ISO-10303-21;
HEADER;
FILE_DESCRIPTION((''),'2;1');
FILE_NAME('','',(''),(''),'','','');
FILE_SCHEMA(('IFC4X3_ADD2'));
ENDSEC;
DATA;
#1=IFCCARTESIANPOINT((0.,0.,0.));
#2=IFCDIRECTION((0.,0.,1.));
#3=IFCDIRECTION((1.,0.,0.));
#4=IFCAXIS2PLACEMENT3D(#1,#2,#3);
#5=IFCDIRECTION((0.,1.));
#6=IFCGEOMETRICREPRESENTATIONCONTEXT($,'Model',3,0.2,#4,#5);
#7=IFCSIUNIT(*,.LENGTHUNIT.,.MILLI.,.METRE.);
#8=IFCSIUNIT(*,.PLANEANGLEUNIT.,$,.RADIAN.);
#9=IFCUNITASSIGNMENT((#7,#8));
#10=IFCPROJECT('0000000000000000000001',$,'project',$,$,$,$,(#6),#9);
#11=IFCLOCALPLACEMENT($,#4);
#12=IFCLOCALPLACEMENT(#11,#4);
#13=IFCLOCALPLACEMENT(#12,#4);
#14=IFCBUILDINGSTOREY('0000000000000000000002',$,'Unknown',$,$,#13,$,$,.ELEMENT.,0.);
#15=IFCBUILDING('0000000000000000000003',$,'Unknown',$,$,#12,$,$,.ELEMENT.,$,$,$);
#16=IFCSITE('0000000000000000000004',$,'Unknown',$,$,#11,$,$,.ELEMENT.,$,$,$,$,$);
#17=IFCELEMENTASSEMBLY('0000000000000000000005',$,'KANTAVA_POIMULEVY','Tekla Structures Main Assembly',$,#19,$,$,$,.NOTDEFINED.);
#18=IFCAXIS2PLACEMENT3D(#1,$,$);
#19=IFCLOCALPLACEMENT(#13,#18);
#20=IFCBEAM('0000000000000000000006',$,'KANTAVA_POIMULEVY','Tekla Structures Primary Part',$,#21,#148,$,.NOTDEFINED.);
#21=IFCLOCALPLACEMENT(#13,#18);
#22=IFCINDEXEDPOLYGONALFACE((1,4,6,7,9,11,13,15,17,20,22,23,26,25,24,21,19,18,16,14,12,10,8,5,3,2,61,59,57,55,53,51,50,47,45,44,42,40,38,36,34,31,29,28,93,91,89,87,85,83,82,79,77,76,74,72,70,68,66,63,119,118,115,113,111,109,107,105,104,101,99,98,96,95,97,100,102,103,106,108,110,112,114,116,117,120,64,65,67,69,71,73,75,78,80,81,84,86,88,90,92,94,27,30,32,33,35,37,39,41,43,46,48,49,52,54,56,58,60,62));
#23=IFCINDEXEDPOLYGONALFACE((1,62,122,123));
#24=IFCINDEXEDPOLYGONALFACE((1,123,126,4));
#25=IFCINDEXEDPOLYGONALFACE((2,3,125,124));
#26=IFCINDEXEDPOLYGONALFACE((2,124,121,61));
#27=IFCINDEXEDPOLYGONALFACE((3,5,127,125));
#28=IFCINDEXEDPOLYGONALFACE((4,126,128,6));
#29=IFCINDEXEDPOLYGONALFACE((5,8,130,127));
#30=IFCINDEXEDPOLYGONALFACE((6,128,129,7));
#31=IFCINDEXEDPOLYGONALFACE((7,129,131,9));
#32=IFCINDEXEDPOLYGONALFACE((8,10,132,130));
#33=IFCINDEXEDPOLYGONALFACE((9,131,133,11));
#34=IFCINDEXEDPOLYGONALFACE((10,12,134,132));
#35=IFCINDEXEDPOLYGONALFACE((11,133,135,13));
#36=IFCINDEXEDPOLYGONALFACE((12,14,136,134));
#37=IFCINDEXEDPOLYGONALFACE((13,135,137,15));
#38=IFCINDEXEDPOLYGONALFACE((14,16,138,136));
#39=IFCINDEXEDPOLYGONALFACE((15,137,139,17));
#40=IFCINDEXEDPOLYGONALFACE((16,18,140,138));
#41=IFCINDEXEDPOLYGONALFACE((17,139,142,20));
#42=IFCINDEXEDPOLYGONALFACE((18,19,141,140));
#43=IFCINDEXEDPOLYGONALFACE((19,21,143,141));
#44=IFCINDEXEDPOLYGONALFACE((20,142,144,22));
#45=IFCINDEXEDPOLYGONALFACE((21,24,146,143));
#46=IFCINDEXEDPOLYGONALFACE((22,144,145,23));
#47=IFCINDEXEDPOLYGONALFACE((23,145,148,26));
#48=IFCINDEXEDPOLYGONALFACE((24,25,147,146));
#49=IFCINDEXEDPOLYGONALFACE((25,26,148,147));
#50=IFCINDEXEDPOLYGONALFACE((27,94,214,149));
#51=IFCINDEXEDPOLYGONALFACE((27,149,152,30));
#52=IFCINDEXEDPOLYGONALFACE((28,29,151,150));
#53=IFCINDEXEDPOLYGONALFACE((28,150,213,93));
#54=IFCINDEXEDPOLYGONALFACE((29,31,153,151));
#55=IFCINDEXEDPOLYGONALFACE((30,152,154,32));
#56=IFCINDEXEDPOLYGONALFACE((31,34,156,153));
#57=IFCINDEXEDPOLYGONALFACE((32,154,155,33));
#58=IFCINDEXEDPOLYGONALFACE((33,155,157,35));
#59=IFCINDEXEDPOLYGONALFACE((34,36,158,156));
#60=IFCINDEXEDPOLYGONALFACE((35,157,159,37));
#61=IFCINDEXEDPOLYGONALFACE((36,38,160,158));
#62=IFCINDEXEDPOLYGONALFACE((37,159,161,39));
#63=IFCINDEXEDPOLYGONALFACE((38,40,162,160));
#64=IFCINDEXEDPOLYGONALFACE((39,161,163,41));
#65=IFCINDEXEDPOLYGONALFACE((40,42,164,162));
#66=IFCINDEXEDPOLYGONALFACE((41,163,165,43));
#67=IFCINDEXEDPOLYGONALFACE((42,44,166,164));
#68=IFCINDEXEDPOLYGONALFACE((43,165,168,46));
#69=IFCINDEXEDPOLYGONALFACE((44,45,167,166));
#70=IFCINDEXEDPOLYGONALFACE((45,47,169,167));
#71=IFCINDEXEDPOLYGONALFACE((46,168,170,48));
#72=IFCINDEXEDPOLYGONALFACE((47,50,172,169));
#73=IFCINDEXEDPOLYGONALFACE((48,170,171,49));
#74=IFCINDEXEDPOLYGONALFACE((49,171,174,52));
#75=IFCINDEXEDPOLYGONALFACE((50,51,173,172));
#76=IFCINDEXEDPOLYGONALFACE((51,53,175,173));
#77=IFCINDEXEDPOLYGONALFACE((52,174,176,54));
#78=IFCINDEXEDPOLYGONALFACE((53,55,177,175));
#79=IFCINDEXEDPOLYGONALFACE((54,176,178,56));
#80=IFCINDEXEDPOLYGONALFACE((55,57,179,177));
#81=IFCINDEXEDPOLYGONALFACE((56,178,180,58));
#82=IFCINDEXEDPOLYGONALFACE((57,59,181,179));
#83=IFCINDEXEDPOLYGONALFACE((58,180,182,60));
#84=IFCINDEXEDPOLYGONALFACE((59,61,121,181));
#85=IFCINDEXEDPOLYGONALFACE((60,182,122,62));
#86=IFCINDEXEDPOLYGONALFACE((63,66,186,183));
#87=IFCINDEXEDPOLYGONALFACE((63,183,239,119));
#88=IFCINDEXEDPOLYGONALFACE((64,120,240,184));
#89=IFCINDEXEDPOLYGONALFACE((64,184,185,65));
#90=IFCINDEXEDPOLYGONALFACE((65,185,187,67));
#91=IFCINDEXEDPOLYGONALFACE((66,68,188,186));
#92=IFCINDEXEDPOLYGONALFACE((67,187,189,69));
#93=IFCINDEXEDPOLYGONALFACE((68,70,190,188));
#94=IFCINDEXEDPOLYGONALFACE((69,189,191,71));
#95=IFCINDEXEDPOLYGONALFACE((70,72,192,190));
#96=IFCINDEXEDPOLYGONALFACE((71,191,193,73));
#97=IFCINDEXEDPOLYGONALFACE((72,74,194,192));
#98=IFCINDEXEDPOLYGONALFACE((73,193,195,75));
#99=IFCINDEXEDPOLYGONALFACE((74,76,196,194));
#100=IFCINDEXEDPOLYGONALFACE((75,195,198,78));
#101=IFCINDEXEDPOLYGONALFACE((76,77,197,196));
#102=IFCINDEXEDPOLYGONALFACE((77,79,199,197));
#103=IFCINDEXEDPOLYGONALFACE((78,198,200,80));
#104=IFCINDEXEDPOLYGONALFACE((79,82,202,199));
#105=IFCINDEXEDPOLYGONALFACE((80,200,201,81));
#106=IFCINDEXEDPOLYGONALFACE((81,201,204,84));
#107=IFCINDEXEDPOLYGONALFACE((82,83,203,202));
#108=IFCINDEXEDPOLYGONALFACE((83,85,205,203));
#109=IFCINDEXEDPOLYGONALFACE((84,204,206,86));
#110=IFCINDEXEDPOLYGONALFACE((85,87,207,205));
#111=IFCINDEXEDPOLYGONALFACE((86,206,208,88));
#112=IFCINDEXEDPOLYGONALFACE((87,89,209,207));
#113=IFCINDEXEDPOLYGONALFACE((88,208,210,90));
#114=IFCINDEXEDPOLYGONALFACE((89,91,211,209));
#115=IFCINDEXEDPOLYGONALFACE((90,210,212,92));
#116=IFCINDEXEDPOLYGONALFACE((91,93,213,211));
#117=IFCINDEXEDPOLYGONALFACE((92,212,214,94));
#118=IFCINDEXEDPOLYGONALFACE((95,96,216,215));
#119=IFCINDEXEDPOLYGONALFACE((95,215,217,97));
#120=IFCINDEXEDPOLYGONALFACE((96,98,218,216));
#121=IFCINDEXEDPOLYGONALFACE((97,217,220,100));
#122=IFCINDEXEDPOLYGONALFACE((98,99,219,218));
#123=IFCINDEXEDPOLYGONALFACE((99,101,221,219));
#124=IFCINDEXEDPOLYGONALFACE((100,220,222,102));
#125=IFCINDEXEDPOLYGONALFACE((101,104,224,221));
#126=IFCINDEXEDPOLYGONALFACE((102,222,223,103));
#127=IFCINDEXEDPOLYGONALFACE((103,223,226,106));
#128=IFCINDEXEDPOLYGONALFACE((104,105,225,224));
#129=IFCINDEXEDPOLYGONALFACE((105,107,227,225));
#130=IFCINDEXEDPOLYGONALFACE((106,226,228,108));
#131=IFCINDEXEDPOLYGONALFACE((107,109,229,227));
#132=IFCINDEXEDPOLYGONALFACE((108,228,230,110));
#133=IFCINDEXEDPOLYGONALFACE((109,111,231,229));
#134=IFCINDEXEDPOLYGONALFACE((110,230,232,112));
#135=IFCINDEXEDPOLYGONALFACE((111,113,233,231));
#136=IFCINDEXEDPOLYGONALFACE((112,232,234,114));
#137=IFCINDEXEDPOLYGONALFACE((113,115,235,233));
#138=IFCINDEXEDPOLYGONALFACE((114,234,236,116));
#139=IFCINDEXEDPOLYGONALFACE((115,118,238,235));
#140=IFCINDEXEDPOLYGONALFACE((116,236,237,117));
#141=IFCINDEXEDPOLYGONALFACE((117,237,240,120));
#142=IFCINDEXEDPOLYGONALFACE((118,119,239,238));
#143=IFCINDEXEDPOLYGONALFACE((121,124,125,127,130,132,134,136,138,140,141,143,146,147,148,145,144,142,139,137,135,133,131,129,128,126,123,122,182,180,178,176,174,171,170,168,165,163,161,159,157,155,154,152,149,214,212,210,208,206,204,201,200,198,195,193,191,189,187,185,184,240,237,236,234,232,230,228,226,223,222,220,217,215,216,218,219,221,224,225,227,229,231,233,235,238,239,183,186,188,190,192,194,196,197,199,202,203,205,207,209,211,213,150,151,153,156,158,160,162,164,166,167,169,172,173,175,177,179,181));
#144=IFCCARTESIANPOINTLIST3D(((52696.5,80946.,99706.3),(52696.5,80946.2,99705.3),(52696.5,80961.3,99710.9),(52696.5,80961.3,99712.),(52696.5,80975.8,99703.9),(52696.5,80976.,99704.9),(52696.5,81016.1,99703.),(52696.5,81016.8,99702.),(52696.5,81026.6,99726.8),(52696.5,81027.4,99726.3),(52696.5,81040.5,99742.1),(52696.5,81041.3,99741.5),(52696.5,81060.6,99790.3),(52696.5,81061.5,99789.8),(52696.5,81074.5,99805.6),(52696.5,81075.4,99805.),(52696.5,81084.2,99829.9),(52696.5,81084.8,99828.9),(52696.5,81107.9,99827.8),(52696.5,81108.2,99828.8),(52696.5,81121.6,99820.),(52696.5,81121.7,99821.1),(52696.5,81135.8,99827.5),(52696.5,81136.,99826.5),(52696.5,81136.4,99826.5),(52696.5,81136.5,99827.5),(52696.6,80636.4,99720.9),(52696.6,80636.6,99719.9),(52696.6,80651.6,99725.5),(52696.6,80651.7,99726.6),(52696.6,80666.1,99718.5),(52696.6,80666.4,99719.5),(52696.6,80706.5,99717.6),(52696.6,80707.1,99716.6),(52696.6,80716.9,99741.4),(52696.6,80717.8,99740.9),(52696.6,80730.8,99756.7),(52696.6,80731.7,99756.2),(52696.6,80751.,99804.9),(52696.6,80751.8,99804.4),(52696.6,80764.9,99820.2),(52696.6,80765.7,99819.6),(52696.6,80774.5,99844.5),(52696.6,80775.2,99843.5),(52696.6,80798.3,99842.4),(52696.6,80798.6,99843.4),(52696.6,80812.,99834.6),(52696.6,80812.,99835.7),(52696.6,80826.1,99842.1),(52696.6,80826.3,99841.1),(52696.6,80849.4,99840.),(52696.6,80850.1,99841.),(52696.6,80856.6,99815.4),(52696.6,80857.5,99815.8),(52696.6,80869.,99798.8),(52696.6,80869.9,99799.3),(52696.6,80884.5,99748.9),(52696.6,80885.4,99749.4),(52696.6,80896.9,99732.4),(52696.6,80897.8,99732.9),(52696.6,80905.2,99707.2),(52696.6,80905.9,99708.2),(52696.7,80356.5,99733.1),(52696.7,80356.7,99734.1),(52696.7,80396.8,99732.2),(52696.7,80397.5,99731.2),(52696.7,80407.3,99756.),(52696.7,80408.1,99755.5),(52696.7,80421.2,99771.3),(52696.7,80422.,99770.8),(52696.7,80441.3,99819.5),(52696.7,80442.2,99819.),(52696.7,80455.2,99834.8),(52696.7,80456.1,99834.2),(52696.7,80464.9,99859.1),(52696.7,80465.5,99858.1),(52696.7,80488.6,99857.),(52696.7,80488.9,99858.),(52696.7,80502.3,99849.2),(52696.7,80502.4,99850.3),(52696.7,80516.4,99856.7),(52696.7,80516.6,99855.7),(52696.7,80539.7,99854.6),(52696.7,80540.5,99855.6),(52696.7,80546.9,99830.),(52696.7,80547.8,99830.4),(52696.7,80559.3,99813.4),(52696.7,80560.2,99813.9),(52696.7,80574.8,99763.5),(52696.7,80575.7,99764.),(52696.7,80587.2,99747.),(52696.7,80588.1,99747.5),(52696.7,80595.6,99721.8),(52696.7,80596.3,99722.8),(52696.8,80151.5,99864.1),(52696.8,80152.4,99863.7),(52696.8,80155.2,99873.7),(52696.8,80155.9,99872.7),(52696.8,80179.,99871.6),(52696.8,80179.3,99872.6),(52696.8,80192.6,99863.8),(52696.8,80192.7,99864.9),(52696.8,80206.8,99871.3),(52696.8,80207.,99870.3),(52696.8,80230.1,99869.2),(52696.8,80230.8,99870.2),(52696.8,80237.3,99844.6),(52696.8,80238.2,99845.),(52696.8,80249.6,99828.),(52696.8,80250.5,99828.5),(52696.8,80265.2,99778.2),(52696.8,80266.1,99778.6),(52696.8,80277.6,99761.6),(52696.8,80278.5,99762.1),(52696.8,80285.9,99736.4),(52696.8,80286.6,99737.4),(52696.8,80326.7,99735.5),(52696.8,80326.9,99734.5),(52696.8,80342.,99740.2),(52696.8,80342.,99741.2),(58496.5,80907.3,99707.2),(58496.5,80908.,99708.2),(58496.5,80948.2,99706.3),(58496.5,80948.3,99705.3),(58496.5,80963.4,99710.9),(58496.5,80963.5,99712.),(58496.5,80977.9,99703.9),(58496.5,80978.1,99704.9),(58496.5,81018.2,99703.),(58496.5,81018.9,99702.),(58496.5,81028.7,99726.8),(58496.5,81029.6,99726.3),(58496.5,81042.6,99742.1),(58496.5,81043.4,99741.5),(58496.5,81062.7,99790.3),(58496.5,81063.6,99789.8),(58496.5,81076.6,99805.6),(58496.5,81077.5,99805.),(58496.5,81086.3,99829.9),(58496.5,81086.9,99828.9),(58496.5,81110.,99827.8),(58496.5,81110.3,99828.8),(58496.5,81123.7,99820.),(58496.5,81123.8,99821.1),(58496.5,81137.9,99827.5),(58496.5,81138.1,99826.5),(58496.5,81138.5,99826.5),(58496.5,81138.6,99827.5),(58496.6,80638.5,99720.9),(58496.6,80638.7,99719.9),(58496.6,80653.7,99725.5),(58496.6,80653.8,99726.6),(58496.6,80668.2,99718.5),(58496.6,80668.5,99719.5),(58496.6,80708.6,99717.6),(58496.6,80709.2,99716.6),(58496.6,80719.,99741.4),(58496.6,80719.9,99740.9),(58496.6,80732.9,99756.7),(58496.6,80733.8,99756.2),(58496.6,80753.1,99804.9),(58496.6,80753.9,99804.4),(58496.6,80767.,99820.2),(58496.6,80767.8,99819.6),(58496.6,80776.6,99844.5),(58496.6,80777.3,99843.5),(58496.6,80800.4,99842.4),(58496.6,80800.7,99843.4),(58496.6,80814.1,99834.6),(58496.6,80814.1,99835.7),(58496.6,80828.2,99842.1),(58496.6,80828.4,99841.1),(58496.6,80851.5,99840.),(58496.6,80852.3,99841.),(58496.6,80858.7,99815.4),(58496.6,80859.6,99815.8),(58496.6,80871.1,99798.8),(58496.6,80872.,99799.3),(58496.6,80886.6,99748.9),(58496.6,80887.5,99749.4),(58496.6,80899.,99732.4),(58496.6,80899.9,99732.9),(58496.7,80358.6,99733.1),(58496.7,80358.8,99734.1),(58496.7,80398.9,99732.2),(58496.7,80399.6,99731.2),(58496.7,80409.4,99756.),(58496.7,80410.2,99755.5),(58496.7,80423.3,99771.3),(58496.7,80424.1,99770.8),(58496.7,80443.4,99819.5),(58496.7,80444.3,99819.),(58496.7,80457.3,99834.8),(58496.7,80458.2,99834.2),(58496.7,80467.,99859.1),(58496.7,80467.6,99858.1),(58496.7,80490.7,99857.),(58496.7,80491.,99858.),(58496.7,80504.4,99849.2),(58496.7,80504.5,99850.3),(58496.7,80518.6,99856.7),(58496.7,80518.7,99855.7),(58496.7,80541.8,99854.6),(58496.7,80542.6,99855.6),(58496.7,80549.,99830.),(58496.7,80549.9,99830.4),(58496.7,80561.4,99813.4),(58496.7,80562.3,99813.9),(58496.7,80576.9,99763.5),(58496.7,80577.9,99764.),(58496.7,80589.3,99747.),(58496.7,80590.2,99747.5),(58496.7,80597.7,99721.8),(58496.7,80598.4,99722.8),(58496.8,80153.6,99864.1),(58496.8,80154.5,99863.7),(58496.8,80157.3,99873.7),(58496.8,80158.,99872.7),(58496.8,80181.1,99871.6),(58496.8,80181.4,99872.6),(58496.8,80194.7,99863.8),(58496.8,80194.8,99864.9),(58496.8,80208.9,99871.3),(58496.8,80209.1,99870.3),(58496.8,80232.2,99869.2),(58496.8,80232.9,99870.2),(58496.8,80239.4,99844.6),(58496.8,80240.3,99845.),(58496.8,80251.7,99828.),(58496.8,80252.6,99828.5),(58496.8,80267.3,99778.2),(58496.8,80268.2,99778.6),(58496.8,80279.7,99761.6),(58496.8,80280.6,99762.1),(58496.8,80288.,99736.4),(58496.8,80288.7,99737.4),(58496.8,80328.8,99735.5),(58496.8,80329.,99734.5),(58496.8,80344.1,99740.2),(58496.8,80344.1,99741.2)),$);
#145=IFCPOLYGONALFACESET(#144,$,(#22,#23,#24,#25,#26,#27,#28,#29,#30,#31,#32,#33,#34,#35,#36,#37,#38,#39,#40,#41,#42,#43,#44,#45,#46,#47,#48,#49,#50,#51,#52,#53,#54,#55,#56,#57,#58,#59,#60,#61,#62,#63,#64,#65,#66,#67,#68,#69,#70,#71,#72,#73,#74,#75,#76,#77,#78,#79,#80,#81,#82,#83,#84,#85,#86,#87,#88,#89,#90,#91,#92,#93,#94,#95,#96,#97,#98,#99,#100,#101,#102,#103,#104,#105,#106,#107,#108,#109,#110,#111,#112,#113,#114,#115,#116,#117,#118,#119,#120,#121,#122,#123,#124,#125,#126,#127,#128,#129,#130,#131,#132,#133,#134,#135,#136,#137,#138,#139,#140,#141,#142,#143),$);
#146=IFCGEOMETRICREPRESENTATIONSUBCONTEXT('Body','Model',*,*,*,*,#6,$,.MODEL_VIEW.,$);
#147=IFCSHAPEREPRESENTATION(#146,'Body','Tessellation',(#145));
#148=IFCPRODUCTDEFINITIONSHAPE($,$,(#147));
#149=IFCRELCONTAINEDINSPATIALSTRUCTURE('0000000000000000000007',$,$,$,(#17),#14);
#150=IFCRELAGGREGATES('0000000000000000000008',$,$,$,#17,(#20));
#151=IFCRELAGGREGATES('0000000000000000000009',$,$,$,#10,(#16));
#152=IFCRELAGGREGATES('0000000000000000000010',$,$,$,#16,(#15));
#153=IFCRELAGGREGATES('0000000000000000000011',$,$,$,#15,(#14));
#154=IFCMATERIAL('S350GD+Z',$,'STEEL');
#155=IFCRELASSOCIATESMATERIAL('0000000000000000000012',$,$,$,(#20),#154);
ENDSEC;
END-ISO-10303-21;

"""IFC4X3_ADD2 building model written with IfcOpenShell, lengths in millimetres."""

from ifc_helpers import new_model, si_unit, direction, frame, origin_with_axes, place, context, subcontext, project, spatial, line, indexed_curve, outline, extrude, material, element, aggregate, save


model = new_model("IFC4X3_ADD2")

# Units and contexts
model_context = context("Model", 3, precision=0.2, world=origin_with_axes(), true_north=direction((0.0, 1.0)))
body_context = subcontext(model_context, "Body", "Model", "MODEL_VIEW")
ifc_project = project(units=[si_unit("LENGTHUNIT", "METRE", prefix="MILLI"), si_unit("PLANEANGLEUNIT", "RADIAN")], contexts=[model_context])

# Site, building, storey
site_placement = place(None, origin_with_axes())
site = spatial("IfcSite", under=ifc_project, at=site_placement, Name="Unknown", CompositionType="ELEMENT")
building_placement = place(site_placement, origin_with_axes())
building = spatial("IfcBuilding", under=site, at=building_placement, Name="Unknown", CompositionType="ELEMENT")
storey_placement = place(building_placement, origin_with_axes())
storey = spatial("IfcBuildingStorey", under=building, at=storey_placement, Name="Unknown", CompositionType="ELEMENT", Elevation=0.0)

# Element assembly, beam
assembly_1_placement = place(storey_placement, frame((58496.6, 80656.5, 99784.6), z_axis=(-0.000363, 0.99889, -0.047106), x_axis=(-1.0, -0.000363, 0.0)))
assembly_1 = element("IfcElementAssembly", 1, at=assembly_1_placement, inside=storey, Name="KANTAVA_POIMULEVY", Description="Tekla Structures Main Assembly", PredefinedType="NOTDEFINED")
ifc_material_1 = material(Name="S350GD+Z", Category="STEEL")
beam_1_placement = place(assembly_1_placement, origin_with_axes())
beam_1 = element("IfcBeam", 2, at=beam_1_placement, material=ifc_material_1, Name="KANTAVA_POIMULEVY", Description="Tekla Structures Primary Part", PredefinedType="NOTDEFINED", context=body_context, shape_type="SolidModel", body=[
    extrude(outline(indexed_curve([(479.5, 65.5), (478.8, 65.5), (465.0, 58.5), (451.2, 65.5), (427.1, 65.5), (418.6, 40.7), (405.5, 24.8), (387.6, -24.3), (374.5, -40.2), (365.1, -64.5), (325.0, -64.5), (310.0, -58.1), (295.0, -64.5), (254.8, -64.5), (245.5, -40.2), (232.4, -24.3), (214.5, 24.8), (201.4, 40.7), (192.9, 65.5), (168.8, 65.5), (155.0, 58.5), (141.2, 65.5), (117.1, 65.5), (108.6, 40.7), (95.5, 24.8), (77.6, -24.3), (64.5, -40.2), (55.1, -64.5), (15.0, -64.5), (0.0, -58.1), (-15.0, -64.5), (-55.2, -64.5), (-64.5, -40.2), (-77.6, -24.3), (-95.5, 24.8), (-108.6, 40.7), (-117.2, 65.5), (-141.2, 65.5), (-155.0, 58.5), (-168.8, 65.5), (-192.9, 65.5), (-201.4, 40.7), (-214.5, 24.8), (-232.4, -24.3), (-245.5, -40.2), (-254.9, -64.5), (-295.0, -64.5), (-310.0, -58.1), (-325.0, -64.5), (-365.2, -64.5), (-374.5, -40.2), (-387.6, -24.3), (-405.5, 24.8), (-418.6, 40.7), (-427.1, 65.5), (-451.2, 65.5), (-465.0, 58.5), (-478.8, 65.5), (-502.9, 65.5), (-506.2, 55.7), (-505.2, 55.4), (-502.1, 64.5), (-479.0, 64.5), (-465.0, 57.3), (-451.0, 64.5), (-427.9, 64.5), (-419.5, 40.2), (-406.4, 24.3), (-388.5, -24.8), (-375.4, -40.7), (-365.9, -65.5), (-324.8, -65.5), (-310.0, -59.1), (-295.2, -65.5), (-254.2, -65.5), (-244.6, -40.7), (-231.5, -24.8), (-213.6, 24.3), (-200.5, 40.2), (-192.1, 64.5), (-169.0, 64.5), (-155.0, 57.3), (-141.0, 64.5), (-117.9, 64.5), (-109.5, 40.2), (-96.4, 24.3), (-78.5, -24.8), (-65.4, -40.7), (-55.9, -65.5), (-14.8, -65.5), (0.0, -59.1), (14.8, -65.5), (55.8, -65.5), (65.4, -40.7), (78.5, -24.8), (96.4, 24.3), (109.5, 40.2), (117.8, 64.5), (141.0, 64.5), (155.0, 57.3), (169.0, 64.5), (192.1, 64.5), (200.5, 40.2), (213.6, 24.3), (231.5, -24.8), (244.6, -40.7), (254.1, -65.5), (295.2, -65.5), (310.0, -59.1), (324.8, -65.5), (365.8, -65.5), (375.4, -40.7), (388.5, -24.8), (406.4, 24.3), (419.5, 40.2), (427.9, 64.5), (451.0, 64.5), (465.0, 57.3), (479.0, 64.5), (479.5, 64.5)], segments=[line(1, 2, 3, 4, 5, 6, 7, 8, 9, 10, 11, 12, 13, 14, 15, 16, 17, 18, 19, 20, 21, 22, 23, 24, 25, 26, 27, 28, 29, 30, 31, 32, 33, 34, 35, 36, 37, 38, 39, 40, 41, 42, 43, 44, 45, 46, 47, 48, 49, 50, 51, 52, 53, 54, 55, 56, 57, 58, 59, 60, 61, 62, 63, 64, 65, 66, 67, 68, 69, 70, 71, 72, 73, 74, 75, 76, 77, 78, 79, 80, 81, 82, 83, 84, 85, 86, 87, 88, 89, 90, 91, 92, 93, 94, 95, 96, 97, 98, 99, 100, 101, 102, 103, 104, 105, 106, 107, 108, 109, 110, 111, 112, 113, 114, 115, 116, 117, 118, 119, 120, 1)])), frame((0.0, 0.0, 0.0), z_axis=(-1.0, 0.0, 0.0), x_axis=(0.0, 0.0, 1.0)), (0.0, 0.0, -1.0), 5800.0),
])
aggregate(assembly_1, [beam_1])

save(model, "model.ifc")
